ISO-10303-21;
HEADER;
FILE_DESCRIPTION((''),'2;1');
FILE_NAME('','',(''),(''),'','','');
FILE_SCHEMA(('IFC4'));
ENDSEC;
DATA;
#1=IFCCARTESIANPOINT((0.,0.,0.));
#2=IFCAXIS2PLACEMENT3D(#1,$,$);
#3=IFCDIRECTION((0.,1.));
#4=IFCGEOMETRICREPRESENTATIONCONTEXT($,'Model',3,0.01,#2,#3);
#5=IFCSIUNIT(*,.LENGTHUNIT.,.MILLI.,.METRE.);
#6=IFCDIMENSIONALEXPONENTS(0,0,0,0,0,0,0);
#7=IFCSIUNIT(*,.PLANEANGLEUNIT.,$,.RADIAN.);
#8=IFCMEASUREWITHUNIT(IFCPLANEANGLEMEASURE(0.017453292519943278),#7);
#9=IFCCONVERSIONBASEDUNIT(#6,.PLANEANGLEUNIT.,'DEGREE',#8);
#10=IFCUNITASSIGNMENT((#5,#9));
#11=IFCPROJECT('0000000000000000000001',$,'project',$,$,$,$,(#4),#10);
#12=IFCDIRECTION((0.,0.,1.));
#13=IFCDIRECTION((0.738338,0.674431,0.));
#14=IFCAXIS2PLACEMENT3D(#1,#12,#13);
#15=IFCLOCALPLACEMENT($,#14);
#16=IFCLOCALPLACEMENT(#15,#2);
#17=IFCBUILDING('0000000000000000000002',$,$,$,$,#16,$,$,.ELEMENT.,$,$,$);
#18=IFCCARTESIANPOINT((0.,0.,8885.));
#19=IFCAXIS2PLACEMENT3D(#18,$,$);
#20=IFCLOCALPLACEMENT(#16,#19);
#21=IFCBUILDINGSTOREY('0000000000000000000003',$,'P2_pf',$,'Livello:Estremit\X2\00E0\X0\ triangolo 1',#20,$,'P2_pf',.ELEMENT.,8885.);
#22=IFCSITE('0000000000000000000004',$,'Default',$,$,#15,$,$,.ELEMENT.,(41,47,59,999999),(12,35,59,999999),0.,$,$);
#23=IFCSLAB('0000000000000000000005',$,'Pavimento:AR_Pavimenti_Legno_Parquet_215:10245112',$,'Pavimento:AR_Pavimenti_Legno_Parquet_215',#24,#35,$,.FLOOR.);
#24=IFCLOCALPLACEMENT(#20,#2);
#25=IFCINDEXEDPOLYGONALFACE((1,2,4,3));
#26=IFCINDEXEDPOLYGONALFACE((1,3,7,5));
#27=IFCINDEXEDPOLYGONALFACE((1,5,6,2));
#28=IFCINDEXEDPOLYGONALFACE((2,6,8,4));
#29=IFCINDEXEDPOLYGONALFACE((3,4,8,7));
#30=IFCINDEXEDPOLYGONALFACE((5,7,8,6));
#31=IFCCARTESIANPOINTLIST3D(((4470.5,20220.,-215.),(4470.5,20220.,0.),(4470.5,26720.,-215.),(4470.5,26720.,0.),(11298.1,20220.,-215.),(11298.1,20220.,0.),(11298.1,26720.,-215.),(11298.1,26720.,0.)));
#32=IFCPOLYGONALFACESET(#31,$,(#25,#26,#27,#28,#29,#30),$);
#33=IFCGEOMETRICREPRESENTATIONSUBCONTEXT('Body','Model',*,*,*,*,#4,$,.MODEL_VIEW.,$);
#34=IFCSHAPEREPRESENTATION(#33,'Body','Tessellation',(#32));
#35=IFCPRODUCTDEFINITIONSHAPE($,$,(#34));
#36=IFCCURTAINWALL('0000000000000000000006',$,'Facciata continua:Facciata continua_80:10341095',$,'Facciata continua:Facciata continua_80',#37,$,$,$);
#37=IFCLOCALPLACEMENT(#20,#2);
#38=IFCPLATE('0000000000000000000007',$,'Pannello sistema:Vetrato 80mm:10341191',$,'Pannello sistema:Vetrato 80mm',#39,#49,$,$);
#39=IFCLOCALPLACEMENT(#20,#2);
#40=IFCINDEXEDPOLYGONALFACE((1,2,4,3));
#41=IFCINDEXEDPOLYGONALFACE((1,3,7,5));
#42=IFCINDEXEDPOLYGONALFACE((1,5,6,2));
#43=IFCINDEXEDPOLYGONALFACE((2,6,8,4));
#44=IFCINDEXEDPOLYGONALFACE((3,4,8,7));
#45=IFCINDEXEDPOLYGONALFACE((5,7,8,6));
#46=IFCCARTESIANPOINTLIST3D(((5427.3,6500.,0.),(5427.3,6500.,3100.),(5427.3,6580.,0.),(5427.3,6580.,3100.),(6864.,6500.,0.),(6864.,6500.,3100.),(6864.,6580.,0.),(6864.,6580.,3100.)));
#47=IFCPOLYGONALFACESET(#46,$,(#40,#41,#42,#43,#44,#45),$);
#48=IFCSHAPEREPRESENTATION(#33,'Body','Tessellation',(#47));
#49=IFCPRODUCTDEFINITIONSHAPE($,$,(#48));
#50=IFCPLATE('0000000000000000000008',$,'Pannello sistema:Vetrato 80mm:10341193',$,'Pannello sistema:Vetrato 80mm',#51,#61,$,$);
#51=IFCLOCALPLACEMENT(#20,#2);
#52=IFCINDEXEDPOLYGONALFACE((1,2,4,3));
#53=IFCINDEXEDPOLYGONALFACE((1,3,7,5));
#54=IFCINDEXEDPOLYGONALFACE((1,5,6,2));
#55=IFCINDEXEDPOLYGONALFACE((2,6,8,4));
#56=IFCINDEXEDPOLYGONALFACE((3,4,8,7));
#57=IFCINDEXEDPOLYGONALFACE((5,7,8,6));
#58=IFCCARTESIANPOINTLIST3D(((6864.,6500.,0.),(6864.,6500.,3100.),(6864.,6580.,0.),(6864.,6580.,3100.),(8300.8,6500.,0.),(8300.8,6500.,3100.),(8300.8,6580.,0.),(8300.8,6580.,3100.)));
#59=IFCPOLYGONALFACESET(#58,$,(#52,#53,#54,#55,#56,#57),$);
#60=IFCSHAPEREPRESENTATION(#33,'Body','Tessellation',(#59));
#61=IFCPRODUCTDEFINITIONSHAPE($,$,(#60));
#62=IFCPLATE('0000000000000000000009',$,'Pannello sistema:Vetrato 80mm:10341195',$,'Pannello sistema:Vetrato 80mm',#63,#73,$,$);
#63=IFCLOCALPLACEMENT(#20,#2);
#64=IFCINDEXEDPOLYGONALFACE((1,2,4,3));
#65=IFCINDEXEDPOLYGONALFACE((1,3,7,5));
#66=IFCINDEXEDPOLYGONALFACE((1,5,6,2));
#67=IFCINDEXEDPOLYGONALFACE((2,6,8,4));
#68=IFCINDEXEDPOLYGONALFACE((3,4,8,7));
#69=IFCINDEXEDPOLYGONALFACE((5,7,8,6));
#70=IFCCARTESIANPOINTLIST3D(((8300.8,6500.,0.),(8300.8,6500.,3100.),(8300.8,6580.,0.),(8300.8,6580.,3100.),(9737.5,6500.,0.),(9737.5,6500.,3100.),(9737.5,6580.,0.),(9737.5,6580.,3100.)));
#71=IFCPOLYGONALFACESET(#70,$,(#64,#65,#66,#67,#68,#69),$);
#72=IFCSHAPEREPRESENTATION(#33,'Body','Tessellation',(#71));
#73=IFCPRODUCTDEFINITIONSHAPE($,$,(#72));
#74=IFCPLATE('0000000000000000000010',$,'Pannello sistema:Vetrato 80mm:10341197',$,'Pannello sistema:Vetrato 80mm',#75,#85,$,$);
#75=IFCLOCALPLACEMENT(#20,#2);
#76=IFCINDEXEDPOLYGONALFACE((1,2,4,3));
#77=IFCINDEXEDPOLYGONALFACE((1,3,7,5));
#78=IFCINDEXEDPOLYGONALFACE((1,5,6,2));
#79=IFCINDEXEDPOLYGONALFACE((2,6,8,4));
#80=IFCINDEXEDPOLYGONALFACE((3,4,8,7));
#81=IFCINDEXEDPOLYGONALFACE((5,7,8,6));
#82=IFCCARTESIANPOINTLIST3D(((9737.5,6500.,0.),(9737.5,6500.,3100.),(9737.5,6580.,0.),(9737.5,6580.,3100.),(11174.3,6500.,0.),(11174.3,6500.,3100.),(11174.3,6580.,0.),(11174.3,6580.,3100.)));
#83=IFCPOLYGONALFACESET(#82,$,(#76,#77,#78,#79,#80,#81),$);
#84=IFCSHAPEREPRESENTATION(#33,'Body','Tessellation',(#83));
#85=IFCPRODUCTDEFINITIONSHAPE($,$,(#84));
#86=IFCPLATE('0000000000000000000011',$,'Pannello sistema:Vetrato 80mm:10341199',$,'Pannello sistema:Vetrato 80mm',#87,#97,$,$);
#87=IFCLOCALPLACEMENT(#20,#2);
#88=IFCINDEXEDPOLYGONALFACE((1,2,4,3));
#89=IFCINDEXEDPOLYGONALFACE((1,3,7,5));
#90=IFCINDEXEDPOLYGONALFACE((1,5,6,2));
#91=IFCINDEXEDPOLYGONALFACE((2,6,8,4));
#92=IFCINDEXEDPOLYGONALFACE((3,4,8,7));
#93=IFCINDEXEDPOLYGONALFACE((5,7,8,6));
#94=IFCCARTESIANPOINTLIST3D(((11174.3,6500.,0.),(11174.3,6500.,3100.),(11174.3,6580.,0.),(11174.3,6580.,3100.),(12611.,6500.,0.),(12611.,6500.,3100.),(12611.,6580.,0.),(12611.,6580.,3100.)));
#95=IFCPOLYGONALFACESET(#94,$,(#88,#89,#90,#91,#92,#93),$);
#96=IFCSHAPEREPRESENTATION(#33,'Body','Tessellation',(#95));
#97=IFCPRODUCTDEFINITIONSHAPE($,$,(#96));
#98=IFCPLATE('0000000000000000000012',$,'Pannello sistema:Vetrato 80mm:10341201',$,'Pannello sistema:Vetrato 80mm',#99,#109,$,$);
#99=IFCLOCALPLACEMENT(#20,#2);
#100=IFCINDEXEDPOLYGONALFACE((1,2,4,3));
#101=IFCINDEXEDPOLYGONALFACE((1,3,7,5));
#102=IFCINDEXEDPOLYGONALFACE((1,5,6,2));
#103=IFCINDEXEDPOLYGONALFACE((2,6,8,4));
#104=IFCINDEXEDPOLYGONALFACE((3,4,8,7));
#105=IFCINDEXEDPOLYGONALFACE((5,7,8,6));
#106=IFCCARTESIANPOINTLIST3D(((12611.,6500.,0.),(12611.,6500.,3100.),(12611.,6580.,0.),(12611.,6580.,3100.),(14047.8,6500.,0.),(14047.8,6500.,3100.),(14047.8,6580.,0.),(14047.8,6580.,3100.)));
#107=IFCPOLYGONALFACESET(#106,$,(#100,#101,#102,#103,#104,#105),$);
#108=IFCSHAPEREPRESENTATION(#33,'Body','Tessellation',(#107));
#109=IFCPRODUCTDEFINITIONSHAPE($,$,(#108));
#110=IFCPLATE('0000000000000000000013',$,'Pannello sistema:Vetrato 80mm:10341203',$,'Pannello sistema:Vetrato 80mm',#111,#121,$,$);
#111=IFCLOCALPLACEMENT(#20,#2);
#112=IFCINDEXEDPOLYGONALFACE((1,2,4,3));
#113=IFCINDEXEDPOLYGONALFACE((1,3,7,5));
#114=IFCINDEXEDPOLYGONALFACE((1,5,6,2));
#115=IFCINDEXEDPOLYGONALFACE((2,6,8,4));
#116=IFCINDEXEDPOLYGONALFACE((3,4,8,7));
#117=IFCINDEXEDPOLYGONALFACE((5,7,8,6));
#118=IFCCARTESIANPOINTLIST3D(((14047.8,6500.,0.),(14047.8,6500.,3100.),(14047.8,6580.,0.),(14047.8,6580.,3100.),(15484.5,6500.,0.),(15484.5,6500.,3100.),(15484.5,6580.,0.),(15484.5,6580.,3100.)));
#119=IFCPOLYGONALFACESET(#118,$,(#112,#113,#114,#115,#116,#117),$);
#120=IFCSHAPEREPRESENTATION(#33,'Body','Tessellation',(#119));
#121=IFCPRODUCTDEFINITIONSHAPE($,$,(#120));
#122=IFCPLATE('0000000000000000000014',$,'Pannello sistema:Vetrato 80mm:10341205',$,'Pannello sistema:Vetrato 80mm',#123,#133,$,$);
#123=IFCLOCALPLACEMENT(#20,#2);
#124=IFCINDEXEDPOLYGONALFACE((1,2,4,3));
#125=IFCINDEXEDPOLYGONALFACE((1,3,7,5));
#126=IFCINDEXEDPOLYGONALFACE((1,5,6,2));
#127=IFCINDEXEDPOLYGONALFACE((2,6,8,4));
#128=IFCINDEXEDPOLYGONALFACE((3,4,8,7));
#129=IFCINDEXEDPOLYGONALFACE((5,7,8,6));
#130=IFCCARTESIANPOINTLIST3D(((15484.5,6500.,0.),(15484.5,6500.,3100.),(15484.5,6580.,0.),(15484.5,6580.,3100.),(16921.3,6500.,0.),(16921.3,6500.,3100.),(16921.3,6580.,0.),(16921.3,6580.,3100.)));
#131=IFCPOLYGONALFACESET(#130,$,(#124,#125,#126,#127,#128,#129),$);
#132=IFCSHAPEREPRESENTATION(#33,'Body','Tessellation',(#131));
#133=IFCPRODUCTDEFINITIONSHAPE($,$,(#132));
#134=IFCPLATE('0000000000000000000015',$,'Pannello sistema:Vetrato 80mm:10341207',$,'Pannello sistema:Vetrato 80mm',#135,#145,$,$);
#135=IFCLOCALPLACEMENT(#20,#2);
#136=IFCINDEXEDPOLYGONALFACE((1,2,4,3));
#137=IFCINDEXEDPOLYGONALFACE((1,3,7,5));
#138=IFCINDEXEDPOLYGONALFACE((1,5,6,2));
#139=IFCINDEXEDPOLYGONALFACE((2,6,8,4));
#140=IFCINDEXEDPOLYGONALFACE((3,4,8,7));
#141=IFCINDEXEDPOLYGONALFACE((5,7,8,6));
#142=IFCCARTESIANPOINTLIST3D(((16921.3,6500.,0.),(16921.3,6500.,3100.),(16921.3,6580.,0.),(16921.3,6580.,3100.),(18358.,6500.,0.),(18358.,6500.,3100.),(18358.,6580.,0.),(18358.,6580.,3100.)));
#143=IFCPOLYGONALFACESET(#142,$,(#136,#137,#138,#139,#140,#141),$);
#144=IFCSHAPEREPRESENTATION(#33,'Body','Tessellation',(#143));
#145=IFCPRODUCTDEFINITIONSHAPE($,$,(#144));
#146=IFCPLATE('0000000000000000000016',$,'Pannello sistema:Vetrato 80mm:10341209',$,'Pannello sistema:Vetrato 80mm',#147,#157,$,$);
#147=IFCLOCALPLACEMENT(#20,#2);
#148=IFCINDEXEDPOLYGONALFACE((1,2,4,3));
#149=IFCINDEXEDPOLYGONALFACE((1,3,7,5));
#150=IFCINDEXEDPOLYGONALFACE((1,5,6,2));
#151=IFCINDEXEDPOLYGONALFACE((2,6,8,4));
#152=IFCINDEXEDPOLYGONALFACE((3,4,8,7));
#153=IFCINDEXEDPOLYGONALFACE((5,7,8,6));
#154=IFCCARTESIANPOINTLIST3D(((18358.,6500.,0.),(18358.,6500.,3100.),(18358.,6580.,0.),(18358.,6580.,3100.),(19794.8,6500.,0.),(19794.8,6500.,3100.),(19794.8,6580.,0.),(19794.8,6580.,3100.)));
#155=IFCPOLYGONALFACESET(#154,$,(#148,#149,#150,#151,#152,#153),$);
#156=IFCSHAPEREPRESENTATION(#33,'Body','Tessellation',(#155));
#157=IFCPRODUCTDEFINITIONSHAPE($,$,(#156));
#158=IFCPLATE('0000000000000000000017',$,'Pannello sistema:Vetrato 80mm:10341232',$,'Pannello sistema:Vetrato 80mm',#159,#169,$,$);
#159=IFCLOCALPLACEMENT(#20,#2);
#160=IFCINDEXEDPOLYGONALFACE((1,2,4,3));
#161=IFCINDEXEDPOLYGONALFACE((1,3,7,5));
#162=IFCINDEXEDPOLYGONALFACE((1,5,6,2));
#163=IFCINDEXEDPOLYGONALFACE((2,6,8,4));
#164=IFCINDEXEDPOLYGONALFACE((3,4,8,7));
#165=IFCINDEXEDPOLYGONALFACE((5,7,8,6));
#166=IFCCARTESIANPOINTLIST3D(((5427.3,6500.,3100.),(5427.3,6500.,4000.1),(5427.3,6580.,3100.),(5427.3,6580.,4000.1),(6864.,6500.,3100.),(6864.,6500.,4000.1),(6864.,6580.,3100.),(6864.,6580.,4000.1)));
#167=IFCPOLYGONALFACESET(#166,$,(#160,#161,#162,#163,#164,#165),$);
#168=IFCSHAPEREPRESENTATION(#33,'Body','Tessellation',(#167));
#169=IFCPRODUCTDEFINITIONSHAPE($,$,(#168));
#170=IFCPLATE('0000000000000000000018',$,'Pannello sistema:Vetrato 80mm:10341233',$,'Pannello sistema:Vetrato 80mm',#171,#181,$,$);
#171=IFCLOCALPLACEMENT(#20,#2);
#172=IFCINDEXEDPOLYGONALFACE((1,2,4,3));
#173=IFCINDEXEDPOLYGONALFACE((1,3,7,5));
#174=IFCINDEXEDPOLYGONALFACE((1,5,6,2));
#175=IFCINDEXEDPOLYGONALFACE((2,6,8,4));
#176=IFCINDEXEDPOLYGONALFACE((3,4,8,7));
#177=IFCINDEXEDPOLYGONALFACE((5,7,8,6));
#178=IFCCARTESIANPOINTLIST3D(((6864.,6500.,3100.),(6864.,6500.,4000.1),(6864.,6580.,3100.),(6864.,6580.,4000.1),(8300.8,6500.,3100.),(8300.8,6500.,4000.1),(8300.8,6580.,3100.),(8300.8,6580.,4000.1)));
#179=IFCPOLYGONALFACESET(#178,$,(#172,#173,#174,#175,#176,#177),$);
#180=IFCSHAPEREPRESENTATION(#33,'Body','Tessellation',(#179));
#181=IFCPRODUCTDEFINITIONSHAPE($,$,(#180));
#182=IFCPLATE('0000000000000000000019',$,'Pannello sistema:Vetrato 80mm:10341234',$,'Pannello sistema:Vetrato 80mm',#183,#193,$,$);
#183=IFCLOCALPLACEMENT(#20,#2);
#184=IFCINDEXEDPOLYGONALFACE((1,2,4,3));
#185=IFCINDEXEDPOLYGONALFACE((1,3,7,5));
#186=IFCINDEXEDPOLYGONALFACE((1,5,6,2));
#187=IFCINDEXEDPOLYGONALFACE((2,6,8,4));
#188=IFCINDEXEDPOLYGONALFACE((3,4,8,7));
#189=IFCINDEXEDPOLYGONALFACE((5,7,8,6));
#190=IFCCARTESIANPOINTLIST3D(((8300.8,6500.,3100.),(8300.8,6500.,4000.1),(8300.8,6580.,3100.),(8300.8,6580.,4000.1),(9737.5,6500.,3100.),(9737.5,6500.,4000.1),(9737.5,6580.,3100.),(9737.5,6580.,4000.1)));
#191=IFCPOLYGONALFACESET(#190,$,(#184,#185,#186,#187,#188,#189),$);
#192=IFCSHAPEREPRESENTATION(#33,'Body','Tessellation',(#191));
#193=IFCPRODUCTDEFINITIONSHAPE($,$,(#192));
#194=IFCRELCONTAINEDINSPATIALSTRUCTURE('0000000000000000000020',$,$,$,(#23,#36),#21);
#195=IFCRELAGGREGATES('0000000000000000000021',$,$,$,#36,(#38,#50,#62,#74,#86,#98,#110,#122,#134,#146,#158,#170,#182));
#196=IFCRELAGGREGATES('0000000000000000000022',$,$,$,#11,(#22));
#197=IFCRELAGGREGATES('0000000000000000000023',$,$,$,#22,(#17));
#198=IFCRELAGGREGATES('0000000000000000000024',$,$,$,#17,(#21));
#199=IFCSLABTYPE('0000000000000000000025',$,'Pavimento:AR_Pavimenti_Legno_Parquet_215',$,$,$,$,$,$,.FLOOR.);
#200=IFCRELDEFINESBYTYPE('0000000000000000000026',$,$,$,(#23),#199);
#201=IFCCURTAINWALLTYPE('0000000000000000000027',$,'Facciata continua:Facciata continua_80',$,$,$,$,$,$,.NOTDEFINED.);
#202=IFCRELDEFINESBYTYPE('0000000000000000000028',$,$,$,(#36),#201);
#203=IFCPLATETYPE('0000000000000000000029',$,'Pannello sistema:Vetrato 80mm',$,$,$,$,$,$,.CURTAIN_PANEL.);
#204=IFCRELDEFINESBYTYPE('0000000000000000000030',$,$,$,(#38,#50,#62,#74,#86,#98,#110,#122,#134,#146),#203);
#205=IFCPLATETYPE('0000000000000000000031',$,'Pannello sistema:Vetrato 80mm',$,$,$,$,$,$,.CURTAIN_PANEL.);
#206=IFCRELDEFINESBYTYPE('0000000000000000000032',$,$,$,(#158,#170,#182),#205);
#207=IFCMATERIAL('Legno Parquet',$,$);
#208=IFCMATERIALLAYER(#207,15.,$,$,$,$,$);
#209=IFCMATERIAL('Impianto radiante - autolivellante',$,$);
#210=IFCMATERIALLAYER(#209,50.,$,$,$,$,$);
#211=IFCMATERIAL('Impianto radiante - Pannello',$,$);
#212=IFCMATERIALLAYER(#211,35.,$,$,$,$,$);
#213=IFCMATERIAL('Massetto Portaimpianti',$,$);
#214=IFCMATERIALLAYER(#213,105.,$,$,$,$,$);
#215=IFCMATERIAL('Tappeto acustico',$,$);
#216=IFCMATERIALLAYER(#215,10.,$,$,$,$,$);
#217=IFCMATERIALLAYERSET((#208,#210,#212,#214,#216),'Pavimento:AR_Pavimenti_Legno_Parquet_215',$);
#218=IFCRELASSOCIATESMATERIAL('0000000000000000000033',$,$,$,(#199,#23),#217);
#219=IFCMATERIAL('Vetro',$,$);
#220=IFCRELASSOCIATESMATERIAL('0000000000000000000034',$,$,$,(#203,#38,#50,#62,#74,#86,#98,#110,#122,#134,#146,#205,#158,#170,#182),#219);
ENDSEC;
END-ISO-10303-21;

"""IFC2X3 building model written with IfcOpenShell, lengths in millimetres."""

from ifc_helpers import new_model, entity, si_unit, converted_unit, direction, frame, frame_2d, origin, origin_2d_with_axis, place, context, subcontext, project, spatial, rectangle, extrude, source, transform, mapped, material, layer, layer_set, layer_usage, type_object, type_shapes, element, aggregate, save


model = new_model("IFC2X3")

# Units and contexts
model_context = context("Model", 3, precision=0.01, world=origin(), true_north=direction((0.0, 1.0)))
body_context = subcontext(model_context, "Body", "Model", "MODEL_VIEW")
ifc_project = project(units=[si_unit("LENGTHUNIT", "METRE", prefix="MILLI"), converted_unit("PLANEANGLEUNIT", "DEGREE", entity("IfcPlaneAngleMeasure", 0.017453292519943278), si_unit("PLANEANGLEUNIT", "RADIAN"), dimensions=[0, 0, 0, 0, 0, 0, 0])], contexts=[model_context])

# Site, building, storey
site_placement = place(None, frame((0.0, 0.0, 0.0), z_axis=(0.0, 0.0, 1.0), x_axis=(0.738338, 0.674431, 0.0)))
site = spatial("IfcSite", under=ifc_project, at=site_placement, Name="Default", CompositionType="ELEMENT", RefLatitude=(41, 47, 59, 999999), RefLongitude=(12, 35, 59, 999999), RefElevation=0.0)
building_placement = place(site_placement, origin())
building = spatial("IfcBuilding", under=site, at=building_placement, CompositionType="ELEMENT")
storey_placement = place(building_placement, frame((0.0, 0.0, 8885.0)))
storey = spatial("IfcBuildingStorey", under=building, at=storey_placement, Name="P2_pf", ObjectType="Livello:Estremità triangolo 1", LongName="P2_pf", CompositionType="ELEMENT", Elevation=8885.0)

# Slab
ifc_material_1 = material(Name="Impianto radiante - autolivellante")
ifc_material_2 = material(Name="Impianto radiante - Pannello")
ifc_material_3 = material(Name="Massetto Portaimpianti")
ifc_material_4 = material(Name="Tappeto acustico")
ifc_material_5 = material(Name="Legno Parquet")
ifc_layer_1 = layer(ifc_material_5, 15.0)
ifc_layer_2 = layer(ifc_material_1, 50.0)
ifc_layer_3 = layer(ifc_material_2, 35.0)
ifc_layer_4 = layer(ifc_material_3, 105.0)
ifc_layer_5 = layer(ifc_material_4, 10.0)
ifc_layer_set_1 = layer_set([ifc_layer_1, ifc_layer_2, ifc_layer_3, ifc_layer_4, ifc_layer_5], Name="Pavimento:AR_Pavimenti_Legno_Parquet_215")
ifc_layer_usage_1 = layer_usage(ifc_layer_set_1, "AXIS3", "POSITIVE", 0.0)
slab_type_1 = type_object("IfcSlabType", Name="Pavimento:AR_Pavimenti_Legno_Parquet_215", PredefinedType="FLOOR", material=ifc_layer_set_1)
slab_1_placement = place(storey_placement, origin())
element("IfcSlab", 1, at=slab_1_placement, inside=storey, type_object=slab_type_1, material=ifc_layer_usage_1, Name="Pavimento:AR_Pavimenti_Legno_Parquet_215:10245112", ObjectType="Pavimento:AR_Pavimenti_Legno_Parquet_215", PredefinedType="FLOOR", context=body_context, shape_type="SweptSolid", body=[
    extrude(rectangle(XDim=6500.0, YDim=6827.6, at=frame_2d((0.0, 0.0), x_axis=(1.0, 0.0))), frame((7884.3, 23470.0, 0.0), z_axis=(0.0, 0.0, -1.0), x_axis=(0.0, 1.0, 0.0)), (0.0, 0.0, 1.0), 215.0),
])

# Curtain wall, plates
curtain_wall_type = type_object("IfcCurtainWallType", Name="Facciata continua:Facciata continua_80", PredefinedType="NOTDEFINED")
curtain_wall_placement = place(storey_placement, frame((0.0, 0.0, -8885.0)))
curtain_wall = element("IfcCurtainWall", 2, at=curtain_wall_placement, inside=storey, type_object=curtain_wall_type, Name="Facciata continua:Facciata continua_80:10341095", ObjectType="Facciata continua:Facciata continua_80")
ifc_material_6 = material(Name="Vetro")
plate_type_1 = type_object("IfcPlateType", Name="Pannello sistema:Vetrato 80mm", PredefinedType="CURTAIN_PANEL", material=ifc_material_6)
shared_shape_1 = source(origin(), body_context, "Body", "SweptSolid", [
    extrude(rectangle(XDim=80.0, YDim=1436.8, at=origin_2d_with_axis()), frame((0.0, -40.0, 0.0), z_axis=(0.0, 0.0, 1.0), x_axis=(0.0, 1.0, 0.0)), (0.0, 0.0, 1.0), 3100.0),
])
type_shapes(plate_type_1, [shared_shape_1])
plate_1_placement = place(curtain_wall_placement, frame((6145.6, 6580.0, 8885.0)))
plate_1 = element("IfcPlate", 3, at=plate_1_placement, type_object=plate_type_1, material=ifc_material_6, Name="Pannello sistema:Vetrato 80mm:10341191", ObjectType="Pannello sistema:Vetrato 80mm", context=body_context, shape_type="MappedRepresentation", body=[
    mapped(shared_shape_1, transform((0.0, 0.0, 0.0), scale=1.0)),
])
plate_2_placement = place(curtain_wall_placement, frame((7582.4, 6580.0, 8885.0)))
plate_2 = element("IfcPlate", 4, at=plate_2_placement, type_object=plate_type_1, material=ifc_material_6, Name="Pannello sistema:Vetrato 80mm:10341193", ObjectType="Pannello sistema:Vetrato 80mm", context=body_context, shape_type="MappedRepresentation", body=[
    mapped(shared_shape_1, transform((0.0, 0.0, 0.0), scale=1.0)),
])
plate_3_placement = place(curtain_wall_placement, frame((9019.1, 6580.0, 8885.0)))
plate_3 = element("IfcPlate", 5, at=plate_3_placement, type_object=plate_type_1, material=ifc_material_6, Name="Pannello sistema:Vetrato 80mm:10341195", ObjectType="Pannello sistema:Vetrato 80mm", context=body_context, shape_type="MappedRepresentation", body=[
    mapped(shared_shape_1, transform((0.0, 0.0, 0.0), scale=1.0)),
])
plate_4_placement = place(curtain_wall_placement, frame((10455.9, 6580.0, 8885.0)))
plate_4 = element("IfcPlate", 6, at=plate_4_placement, type_object=plate_type_1, material=ifc_material_6, Name="Pannello sistema:Vetrato 80mm:10341197", ObjectType="Pannello sistema:Vetrato 80mm", context=body_context, shape_type="MappedRepresentation", body=[
    mapped(shared_shape_1, transform((0.0, 0.0, 0.0), scale=1.0)),
])
plate_5_placement = place(curtain_wall_placement, frame((11892.6, 6580.0, 8885.0)))
plate_5 = element("IfcPlate", 7, at=plate_5_placement, type_object=plate_type_1, material=ifc_material_6, Name="Pannello sistema:Vetrato 80mm:10341199", ObjectType="Pannello sistema:Vetrato 80mm", context=body_context, shape_type="MappedRepresentation", body=[
    mapped(shared_shape_1, transform((0.0, 0.0, 0.0), scale=1.0)),
])
plate_6_placement = place(curtain_wall_placement, frame((13329.4, 6580.0, 8885.0)))
plate_6 = element("IfcPlate", 8, at=plate_6_placement, type_object=plate_type_1, material=ifc_material_6, Name="Pannello sistema:Vetrato 80mm:10341201", ObjectType="Pannello sistema:Vetrato 80mm", context=body_context, shape_type="MappedRepresentation", body=[
    mapped(shared_shape_1, transform((0.0, 0.0, 0.0), scale=1.0)),
])
plate_7_placement = place(curtain_wall_placement, frame((14766.1, 6580.0, 8885.0)))
plate_7 = element("IfcPlate", 9, at=plate_7_placement, type_object=plate_type_1, material=ifc_material_6, Name="Pannello sistema:Vetrato 80mm:10341203", ObjectType="Pannello sistema:Vetrato 80mm", context=body_context, shape_type="MappedRepresentation", body=[
    mapped(shared_shape_1, transform((0.0, 0.0, 0.0), scale=1.0)),
])
plate_8_placement = place(curtain_wall_placement, frame((16202.9, 6580.0, 8885.0)))
plate_8 = element("IfcPlate", 10, at=plate_8_placement, type_object=plate_type_1, material=ifc_material_6, Name="Pannello sistema:Vetrato 80mm:10341205", ObjectType="Pannello sistema:Vetrato 80mm", context=body_context, shape_type="MappedRepresentation", body=[
    mapped(shared_shape_1, transform((0.0, 0.0, 0.0), scale=1.0)),
])
plate_9_placement = place(curtain_wall_placement, frame((17639.6, 6580.0, 8885.0)))
plate_9 = element("IfcPlate", 11, at=plate_9_placement, type_object=plate_type_1, material=ifc_material_6, Name="Pannello sistema:Vetrato 80mm:10341207", ObjectType="Pannello sistema:Vetrato 80mm", context=body_context, shape_type="MappedRepresentation", body=[
    mapped(shared_shape_1, transform((0.0, 0.0, 0.0), scale=1.0)),
])
plate_10_placement = place(curtain_wall_placement, frame((19076.4, 6580.0, 8885.0)))
plate_10 = element("IfcPlate", 12, at=plate_10_placement, type_object=plate_type_1, material=ifc_material_6, Name="Pannello sistema:Vetrato 80mm:10341209", ObjectType="Pannello sistema:Vetrato 80mm", context=body_context, shape_type="MappedRepresentation", body=[
    mapped(shared_shape_1, transform((0.0, 0.0, 0.0), scale=1.0)),
])
plate_type_2 = type_object("IfcPlateType", Name="Pannello sistema:Vetrato 80mm", PredefinedType="CURTAIN_PANEL", material=ifc_material_6)
shared_shape_2 = source(origin(), body_context, "Body", "SweptSolid", [
    extrude(rectangle(XDim=80.0, YDim=1436.8, at=origin_2d_with_axis()), frame((0.0, -40.0, 0.0), z_axis=(0.0, 0.0, 1.0), x_axis=(0.0, 1.0, 0.0)), (0.0, 0.0, 1.0), 900.1),
])
type_shapes(plate_type_2, [shared_shape_2])
plate_11_placement = place(curtain_wall_placement, frame((6145.6, 6580.0, 11985.0)))
plate_11 = element("IfcPlate", 13, at=plate_11_placement, type_object=plate_type_2, material=ifc_material_6, Name="Pannello sistema:Vetrato 80mm:10341232", ObjectType="Pannello sistema:Vetrato 80mm", context=body_context, shape_type="MappedRepresentation", body=[
    mapped(shared_shape_2, transform((0.0, 0.0, 0.0), scale=1.0)),
])
plate_12_placement = place(curtain_wall_placement, frame((7582.4, 6580.0, 11985.0)))
plate_12 = element("IfcPlate", 14, at=plate_12_placement, type_object=plate_type_2, material=ifc_material_6, Name="Pannello sistema:Vetrato 80mm:10341233", ObjectType="Pannello sistema:Vetrato 80mm", context=body_context, shape_type="MappedRepresentation", body=[
    mapped(shared_shape_2, transform((0.0, 0.0, 0.0), scale=1.0)),
])
plate_13_placement = place(curtain_wall_placement, frame((9019.1, 6580.0, 11985.0)))
plate_13 = element("IfcPlate", 15, at=plate_13_placement, type_object=plate_type_2, material=ifc_material_6, Name="Pannello sistema:Vetrato 80mm:10341234", ObjectType="Pannello sistema:Vetrato 80mm", context=body_context, shape_type="MappedRepresentation", body=[
    mapped(shared_shape_2, transform((0.0, 0.0, 0.0), scale=1.0)),
])
aggregate(curtain_wall, [plate_1, plate_2, plate_3, plate_4, plate_5, plate_6, plate_7, plate_8, plate_9, plate_10, plate_11, plate_12, plate_13])

save(model, "model.ifc")
